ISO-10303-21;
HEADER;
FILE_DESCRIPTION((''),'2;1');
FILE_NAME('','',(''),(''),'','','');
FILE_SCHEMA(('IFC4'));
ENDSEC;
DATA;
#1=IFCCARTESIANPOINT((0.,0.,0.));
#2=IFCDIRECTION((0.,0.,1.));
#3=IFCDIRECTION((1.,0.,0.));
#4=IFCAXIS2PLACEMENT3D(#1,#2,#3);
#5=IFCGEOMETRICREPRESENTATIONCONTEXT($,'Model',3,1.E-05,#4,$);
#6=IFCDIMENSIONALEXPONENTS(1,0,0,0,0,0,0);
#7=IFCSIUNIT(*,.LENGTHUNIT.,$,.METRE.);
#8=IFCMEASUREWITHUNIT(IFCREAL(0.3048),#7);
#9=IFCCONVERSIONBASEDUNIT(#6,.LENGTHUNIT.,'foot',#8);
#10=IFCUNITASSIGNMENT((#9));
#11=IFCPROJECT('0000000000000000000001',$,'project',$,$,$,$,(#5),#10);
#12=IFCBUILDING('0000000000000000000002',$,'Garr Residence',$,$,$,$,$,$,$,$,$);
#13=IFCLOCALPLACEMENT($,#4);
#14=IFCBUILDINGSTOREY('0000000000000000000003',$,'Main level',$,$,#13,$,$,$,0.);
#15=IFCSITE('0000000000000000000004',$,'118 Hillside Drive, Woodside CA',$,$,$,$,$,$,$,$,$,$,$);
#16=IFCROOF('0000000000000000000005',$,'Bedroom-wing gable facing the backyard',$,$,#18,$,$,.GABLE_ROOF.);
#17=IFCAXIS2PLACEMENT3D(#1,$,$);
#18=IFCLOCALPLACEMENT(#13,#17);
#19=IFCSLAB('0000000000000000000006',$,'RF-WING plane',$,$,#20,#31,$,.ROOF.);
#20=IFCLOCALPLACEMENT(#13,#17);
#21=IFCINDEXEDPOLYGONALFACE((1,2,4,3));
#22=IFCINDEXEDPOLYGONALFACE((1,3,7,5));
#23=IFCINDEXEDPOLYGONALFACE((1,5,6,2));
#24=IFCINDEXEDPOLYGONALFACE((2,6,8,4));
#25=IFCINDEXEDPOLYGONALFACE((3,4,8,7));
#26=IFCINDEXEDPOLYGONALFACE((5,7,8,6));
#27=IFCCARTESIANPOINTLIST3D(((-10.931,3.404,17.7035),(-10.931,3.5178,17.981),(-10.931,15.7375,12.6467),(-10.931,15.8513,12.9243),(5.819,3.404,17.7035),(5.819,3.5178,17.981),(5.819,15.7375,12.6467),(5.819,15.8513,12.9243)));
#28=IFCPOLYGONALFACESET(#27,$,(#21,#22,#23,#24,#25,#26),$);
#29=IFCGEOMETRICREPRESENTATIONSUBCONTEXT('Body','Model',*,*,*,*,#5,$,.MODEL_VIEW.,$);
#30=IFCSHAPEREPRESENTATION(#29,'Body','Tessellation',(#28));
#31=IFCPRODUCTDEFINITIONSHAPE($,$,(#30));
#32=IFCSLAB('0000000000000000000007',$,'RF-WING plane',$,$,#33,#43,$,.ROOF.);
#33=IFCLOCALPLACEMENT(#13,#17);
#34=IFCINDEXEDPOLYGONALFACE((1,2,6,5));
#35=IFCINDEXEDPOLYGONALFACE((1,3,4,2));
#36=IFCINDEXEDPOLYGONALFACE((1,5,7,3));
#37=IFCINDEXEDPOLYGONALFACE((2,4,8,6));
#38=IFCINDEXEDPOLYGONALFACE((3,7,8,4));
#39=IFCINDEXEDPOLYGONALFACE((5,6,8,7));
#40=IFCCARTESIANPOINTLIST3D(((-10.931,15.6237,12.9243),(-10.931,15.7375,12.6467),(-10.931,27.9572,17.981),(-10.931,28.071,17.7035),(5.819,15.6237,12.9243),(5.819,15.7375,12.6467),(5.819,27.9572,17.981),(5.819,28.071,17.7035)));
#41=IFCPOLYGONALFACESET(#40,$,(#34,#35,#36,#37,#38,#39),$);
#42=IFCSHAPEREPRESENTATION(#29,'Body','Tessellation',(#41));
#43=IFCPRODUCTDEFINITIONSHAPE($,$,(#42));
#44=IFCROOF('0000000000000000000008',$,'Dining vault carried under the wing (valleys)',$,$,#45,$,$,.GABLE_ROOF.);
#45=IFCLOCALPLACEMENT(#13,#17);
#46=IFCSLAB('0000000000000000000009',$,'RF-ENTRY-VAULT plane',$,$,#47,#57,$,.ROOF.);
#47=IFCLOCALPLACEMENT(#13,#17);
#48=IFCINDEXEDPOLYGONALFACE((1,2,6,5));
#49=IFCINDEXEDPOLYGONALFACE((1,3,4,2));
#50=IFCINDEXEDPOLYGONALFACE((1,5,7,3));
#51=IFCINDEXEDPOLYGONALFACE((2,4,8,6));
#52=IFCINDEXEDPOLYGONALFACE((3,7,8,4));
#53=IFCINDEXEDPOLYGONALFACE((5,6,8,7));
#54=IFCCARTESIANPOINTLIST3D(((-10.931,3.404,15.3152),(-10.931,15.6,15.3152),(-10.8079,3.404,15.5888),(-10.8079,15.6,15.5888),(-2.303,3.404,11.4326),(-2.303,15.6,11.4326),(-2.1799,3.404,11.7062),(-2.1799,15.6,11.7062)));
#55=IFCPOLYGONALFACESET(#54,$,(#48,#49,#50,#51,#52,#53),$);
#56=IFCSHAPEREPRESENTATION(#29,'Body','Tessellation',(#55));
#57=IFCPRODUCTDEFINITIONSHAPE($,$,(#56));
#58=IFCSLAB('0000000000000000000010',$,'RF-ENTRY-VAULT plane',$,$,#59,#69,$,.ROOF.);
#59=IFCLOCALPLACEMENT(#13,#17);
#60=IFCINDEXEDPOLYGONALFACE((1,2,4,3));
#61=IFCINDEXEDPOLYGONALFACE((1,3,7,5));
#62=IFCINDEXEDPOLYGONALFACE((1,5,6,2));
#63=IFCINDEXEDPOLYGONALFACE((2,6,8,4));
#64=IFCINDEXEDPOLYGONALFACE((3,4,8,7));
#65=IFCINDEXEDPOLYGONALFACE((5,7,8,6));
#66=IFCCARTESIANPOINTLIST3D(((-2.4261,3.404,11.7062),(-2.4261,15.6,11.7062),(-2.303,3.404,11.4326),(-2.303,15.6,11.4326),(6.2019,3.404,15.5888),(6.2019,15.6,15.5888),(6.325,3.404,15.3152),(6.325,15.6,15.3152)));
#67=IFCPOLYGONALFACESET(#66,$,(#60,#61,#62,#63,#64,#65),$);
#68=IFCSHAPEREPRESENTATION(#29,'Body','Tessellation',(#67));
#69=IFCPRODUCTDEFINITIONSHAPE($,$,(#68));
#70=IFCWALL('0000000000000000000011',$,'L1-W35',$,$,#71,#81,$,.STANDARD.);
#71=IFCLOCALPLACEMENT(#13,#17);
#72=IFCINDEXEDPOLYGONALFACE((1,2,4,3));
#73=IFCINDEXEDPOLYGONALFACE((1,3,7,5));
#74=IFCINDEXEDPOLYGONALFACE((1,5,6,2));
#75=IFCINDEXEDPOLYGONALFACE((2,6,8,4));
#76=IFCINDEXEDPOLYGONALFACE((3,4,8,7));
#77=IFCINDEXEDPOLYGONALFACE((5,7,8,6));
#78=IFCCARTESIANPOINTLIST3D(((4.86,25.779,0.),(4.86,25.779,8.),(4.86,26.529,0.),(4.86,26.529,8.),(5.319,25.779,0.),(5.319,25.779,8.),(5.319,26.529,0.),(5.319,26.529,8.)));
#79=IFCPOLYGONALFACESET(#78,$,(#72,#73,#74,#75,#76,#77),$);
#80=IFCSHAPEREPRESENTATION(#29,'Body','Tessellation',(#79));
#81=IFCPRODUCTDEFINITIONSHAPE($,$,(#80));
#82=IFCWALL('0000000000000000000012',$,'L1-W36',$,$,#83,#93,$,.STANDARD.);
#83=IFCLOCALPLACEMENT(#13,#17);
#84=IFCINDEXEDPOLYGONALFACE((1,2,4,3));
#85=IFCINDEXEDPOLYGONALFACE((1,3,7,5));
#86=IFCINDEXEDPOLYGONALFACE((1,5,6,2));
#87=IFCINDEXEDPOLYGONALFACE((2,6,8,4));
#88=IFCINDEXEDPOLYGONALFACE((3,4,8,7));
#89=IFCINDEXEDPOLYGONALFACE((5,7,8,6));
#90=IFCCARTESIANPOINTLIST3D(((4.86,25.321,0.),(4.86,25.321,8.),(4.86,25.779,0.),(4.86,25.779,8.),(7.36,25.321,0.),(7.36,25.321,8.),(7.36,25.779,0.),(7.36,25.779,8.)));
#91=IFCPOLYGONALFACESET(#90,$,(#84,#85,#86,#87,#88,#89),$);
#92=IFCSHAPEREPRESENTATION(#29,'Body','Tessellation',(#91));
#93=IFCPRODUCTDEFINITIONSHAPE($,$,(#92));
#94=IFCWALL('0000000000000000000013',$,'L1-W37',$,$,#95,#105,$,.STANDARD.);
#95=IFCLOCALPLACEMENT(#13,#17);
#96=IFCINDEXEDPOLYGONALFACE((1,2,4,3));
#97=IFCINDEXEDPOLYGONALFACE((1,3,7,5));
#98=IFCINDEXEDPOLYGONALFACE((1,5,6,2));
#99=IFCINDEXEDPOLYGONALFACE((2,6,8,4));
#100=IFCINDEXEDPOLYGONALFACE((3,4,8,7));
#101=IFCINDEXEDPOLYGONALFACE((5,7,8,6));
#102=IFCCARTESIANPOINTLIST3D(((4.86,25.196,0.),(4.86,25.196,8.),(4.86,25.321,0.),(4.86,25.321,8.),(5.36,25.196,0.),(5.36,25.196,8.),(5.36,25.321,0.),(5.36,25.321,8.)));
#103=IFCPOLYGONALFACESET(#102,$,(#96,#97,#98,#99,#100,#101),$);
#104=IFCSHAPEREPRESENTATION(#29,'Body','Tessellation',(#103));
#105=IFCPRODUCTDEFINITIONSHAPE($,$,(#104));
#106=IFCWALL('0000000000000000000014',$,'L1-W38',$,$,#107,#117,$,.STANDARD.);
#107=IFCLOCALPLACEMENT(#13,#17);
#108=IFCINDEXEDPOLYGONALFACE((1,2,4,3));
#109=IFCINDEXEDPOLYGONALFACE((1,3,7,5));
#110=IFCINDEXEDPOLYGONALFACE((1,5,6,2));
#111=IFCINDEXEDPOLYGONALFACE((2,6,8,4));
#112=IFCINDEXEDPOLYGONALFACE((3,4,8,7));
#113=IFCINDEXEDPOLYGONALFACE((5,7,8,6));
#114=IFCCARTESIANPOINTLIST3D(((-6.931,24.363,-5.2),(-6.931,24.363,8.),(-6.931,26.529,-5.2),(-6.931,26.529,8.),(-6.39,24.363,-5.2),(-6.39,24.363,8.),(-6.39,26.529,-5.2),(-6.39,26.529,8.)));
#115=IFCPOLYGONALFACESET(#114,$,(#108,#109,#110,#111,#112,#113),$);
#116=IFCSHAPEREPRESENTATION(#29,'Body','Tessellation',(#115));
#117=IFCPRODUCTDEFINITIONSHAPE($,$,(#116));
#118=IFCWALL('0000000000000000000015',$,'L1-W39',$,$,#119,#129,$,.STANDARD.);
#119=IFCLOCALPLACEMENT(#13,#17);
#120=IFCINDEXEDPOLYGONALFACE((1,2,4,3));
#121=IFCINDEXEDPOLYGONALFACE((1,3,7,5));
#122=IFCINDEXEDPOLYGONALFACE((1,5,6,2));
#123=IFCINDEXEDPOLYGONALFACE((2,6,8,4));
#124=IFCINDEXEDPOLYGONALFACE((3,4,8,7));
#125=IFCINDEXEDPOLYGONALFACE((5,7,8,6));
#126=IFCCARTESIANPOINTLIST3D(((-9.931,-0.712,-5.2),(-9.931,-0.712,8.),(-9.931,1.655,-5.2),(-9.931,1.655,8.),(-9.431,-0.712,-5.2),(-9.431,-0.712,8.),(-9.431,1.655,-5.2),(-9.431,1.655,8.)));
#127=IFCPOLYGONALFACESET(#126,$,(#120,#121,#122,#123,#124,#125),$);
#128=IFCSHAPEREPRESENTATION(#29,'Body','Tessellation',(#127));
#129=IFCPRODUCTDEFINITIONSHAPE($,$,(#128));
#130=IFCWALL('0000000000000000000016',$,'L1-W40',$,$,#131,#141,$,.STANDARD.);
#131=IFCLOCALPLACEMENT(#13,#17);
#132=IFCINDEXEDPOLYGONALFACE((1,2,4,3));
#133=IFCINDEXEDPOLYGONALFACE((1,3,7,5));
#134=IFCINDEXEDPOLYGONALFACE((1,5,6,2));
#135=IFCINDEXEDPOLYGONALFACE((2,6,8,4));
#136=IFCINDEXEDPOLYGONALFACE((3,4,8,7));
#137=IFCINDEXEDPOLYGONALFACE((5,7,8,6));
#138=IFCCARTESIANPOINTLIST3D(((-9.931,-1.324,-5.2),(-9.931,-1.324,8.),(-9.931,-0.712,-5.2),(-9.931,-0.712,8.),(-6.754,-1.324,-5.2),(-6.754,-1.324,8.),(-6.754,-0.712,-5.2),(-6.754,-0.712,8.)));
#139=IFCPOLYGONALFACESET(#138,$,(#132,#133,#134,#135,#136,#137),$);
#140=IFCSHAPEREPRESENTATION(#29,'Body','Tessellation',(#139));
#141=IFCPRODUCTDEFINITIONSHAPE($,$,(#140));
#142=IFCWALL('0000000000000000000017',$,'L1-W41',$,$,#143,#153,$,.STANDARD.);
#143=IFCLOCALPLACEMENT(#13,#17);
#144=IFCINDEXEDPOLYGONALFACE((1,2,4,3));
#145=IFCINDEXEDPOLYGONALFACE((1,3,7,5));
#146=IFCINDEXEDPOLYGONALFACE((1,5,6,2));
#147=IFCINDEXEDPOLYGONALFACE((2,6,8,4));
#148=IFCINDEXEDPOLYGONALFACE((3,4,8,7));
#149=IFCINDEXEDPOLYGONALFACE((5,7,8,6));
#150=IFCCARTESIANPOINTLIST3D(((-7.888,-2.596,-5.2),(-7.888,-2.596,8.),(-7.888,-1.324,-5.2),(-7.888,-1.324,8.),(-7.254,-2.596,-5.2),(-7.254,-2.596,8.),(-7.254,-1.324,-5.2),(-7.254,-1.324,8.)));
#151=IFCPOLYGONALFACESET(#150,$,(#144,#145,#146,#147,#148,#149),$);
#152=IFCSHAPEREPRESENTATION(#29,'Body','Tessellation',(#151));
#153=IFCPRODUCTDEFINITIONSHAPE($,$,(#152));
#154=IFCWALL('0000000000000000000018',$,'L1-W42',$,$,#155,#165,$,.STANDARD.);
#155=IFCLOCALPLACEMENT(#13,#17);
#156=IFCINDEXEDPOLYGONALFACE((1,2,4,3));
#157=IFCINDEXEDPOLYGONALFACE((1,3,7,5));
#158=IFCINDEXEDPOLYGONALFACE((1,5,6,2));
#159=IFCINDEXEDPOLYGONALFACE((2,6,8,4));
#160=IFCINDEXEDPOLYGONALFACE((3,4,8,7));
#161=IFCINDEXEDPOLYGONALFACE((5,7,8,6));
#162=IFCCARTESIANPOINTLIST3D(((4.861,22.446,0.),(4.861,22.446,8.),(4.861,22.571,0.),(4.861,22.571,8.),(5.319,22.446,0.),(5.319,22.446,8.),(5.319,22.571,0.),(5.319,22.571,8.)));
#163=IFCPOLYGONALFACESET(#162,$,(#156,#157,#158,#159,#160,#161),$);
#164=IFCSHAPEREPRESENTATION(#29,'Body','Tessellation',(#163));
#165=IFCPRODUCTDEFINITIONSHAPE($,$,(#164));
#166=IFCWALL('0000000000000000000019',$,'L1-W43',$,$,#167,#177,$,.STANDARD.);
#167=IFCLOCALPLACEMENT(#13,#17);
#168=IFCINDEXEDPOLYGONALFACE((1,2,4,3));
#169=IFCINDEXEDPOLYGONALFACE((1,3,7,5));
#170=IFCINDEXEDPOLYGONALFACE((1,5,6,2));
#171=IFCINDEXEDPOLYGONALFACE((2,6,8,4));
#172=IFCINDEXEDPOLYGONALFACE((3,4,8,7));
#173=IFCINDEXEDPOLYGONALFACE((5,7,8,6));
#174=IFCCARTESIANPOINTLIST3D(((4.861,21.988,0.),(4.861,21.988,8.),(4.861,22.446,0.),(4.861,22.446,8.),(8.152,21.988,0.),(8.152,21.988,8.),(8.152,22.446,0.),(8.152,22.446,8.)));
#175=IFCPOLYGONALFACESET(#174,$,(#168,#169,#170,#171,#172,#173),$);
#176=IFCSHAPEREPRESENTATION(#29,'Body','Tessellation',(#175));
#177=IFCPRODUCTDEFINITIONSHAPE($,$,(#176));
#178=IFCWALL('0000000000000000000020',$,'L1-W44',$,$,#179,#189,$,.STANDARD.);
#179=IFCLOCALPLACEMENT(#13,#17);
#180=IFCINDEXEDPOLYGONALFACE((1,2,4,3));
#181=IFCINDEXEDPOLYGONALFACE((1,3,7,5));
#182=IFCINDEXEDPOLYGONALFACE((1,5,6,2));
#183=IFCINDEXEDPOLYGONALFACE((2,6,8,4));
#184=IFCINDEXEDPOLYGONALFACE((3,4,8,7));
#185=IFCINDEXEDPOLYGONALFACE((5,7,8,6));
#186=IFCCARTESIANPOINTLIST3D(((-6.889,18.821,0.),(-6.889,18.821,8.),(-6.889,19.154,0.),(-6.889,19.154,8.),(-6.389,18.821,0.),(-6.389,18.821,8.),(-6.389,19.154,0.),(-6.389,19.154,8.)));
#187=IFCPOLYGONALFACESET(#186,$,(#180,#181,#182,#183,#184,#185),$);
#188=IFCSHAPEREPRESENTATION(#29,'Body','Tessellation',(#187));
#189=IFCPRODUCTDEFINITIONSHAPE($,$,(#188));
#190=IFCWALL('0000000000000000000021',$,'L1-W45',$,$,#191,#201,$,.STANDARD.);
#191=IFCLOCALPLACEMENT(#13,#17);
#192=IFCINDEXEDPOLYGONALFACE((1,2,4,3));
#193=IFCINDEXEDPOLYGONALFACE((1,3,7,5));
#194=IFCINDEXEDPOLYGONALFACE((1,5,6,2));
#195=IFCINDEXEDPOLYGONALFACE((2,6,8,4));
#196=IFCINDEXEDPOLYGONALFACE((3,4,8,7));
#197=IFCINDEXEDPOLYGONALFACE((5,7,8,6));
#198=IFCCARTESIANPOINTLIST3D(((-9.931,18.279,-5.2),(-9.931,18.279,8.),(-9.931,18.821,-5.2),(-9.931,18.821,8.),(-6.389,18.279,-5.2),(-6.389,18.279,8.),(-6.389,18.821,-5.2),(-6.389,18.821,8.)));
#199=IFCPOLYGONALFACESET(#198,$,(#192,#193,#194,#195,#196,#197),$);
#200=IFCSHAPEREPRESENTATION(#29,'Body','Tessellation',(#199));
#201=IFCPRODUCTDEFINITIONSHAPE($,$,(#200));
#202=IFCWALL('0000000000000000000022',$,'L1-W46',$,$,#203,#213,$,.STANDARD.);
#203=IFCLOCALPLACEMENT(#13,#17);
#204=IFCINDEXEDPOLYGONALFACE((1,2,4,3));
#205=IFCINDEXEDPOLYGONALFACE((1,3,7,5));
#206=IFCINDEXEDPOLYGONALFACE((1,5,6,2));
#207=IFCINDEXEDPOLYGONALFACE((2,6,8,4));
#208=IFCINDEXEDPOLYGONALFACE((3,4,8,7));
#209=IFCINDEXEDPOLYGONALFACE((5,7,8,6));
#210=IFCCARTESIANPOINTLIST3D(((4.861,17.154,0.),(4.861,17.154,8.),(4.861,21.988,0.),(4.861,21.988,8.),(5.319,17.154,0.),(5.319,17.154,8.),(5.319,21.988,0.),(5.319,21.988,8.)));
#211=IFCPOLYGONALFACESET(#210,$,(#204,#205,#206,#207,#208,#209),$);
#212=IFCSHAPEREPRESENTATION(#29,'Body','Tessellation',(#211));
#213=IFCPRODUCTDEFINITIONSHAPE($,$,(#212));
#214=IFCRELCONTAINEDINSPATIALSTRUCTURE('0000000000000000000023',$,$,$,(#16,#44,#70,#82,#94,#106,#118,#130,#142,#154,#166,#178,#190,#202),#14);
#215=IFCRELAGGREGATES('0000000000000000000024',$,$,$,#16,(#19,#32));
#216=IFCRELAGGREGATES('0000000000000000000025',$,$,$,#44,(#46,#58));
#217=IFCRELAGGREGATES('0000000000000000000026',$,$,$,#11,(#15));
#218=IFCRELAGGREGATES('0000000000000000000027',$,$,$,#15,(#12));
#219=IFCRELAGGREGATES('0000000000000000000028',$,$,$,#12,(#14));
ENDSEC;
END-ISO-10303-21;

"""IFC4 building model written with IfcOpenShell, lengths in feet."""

from ifc_helpers import new_model, entity, si_unit, converted_unit, frame, origin, origin_with_axes, place, context, subcontext, project, spatial, polyline, outline, extrude, element, aggregate, save


model = new_model("IFC4")

# Units and contexts
model_context = context("Model", 3, precision=1e-05, world=origin_with_axes())
body_context = subcontext(model_context, "Body", "Model", "MODEL_VIEW")
ifc_project = project(units=[converted_unit("LENGTHUNIT", "foot", entity("IfcReal", 0.3048), si_unit("LENGTHUNIT", "METRE"), dimensions=[1, 0, 0, 0, 0, 0, 0])], contexts=[model_context])

# Site, building, storey
site = spatial("IfcSite", under=ifc_project, Name="118 Hillside Drive, Woodside CA")
building = spatial("IfcBuilding", under=site, Name="Garr Residence")
storey_placement = place(None, origin_with_axes())
storey = spatial("IfcBuildingStorey", under=building, at=storey_placement, Name="Main level", Elevation=0.0)

# Roofs, slabs
roof_1 = element("IfcRoof", 1, inside=storey, Name="Bedroom-wing gable facing the backyard", PredefinedType="GABLE_ROOF")
slab_1_placement = place(None, frame((-10.931, 15.7375, 12.6467), z_axis=(0.0, 0.379353, 0.925252), x_axis=(1.0, 0.0, 0.0)))
slab_1 = element("IfcSlab", 2, at=slab_1_placement, Name="RF-WING plane", PredefinedType="ROOF", context=body_context, shape_type="SweptSolid", body=[
    extrude(outline(polyline([(0.0, 0.0), (16.75, 0.0), (16.75, -13.3299), (0.0, -13.3299), (0.0, 0.0)])), origin(), (0.0, 0.0, 1.0), 0.3),
])
slab_2_placement = place(None, frame((-10.931, 15.7375, 12.6467), z_axis=(0.0, -0.379353, 0.925252), x_axis=(1.0, 0.0, 0.0)))
slab_2 = element("IfcSlab", 3, at=slab_2_placement, Name="RF-WING plane", PredefinedType="ROOF", context=body_context, shape_type="SweptSolid", body=[
    extrude(outline(polyline([(0.0, 0.0), (16.75, 0.0), (16.75, 13.3299), (0.0, 13.3299), (0.0, 0.0)])), origin(), (0.0, 0.0, 1.0), 0.3),
])
aggregate(roof_1, [slab_1, slab_2])
roof_2 = element("IfcRoof", 4, inside=storey, Name="Dining vault carried under the wing (valleys)", PredefinedType="GABLE_ROOF")
slab_3_placement = place(None, frame((-2.303, 3.404, 11.4326), z_axis=(0.410365, 0.0, 0.911922), x_axis=(0.0, 1.0, 0.0)))
slab_3 = element("IfcSlab", 5, at=slab_3_placement, Name="RF-ENTRY-VAULT plane", PredefinedType="ROOF", context=body_context, shape_type="SweptSolid", body=[
    extrude(outline(polyline([(0.0, 0.0), (12.196, 0.0), (12.196, 9.4613), (0.0, 9.4613), (0.0, 0.0)])), origin(), (0.0, 0.0, 1.0), 0.3),
])
slab_4_placement = place(None, frame((-2.303, 3.404, 11.4326), z_axis=(-0.410365, 0.0, 0.911922), x_axis=(0.0, 1.0, 0.0)))
slab_4 = element("IfcSlab", 6, at=slab_4_placement, Name="RF-ENTRY-VAULT plane", PredefinedType="ROOF", context=body_context, shape_type="SweptSolid", body=[
    extrude(outline(polyline([(0.0, 0.0), (12.196, 0.0), (12.196, -9.4613), (0.0, -9.4613), (0.0, 0.0)])), origin(), (0.0, 0.0, 1.0), 0.3),
])
aggregate(roof_2, [slab_3, slab_4])

# Walls
wall_1_placement = place(storey_placement, origin_with_axes())
element("IfcWall", 7, at=wall_1_placement, inside=storey, Name="L1-W35", PredefinedType="STANDARD", context=body_context, shape_type="SweptSolid", body=[
    extrude(outline(polyline([(5.319, 25.779), (5.319, 26.529), (4.86, 26.529), (4.86, 25.779), (5.319, 25.779)])), origin(), (0.0, 0.0, 1.0), 8.0),
])
wall_2_placement = place(storey_placement, origin_with_axes())
element("IfcWall", 8, at=wall_2_placement, inside=storey, Name="L1-W36", PredefinedType="STANDARD", context=body_context, shape_type="SweptSolid", body=[
    extrude(outline(polyline([(7.36, 25.321), (7.36, 25.779), (4.86, 25.779), (4.86, 25.321), (7.36, 25.321)])), origin(), (0.0, 0.0, 1.0), 8.0),
])
wall_3_placement = place(storey_placement, origin_with_axes())
element("IfcWall", 9, at=wall_3_placement, inside=storey, Name="L1-W37", PredefinedType="STANDARD", context=body_context, shape_type="SweptSolid", body=[
    extrude(outline(polyline([(5.36, 25.196), (5.36, 25.321), (4.86, 25.321), (4.86, 25.196), (5.36, 25.196)])), origin(), (0.0, 0.0, 1.0), 8.0),
])
wall_4_placement = place(storey_placement, frame((0.0, 0.0, -5.2), z_axis=(0.0, 0.0, 1.0), x_axis=(1.0, 0.0, 0.0)))
element("IfcWall", 10, at=wall_4_placement, inside=storey, Name="L1-W38", PredefinedType="STANDARD", context=body_context, shape_type="SweptSolid", body=[
    extrude(outline(polyline([(-6.39, 24.363), (-6.39, 26.529), (-6.931, 26.529), (-6.931, 24.363), (-6.39, 24.363)])), origin(), (0.0, 0.0, 1.0), 13.2),
])
wall_5_placement = place(storey_placement, frame((0.0, 0.0, -5.2), z_axis=(0.0, 0.0, 1.0), x_axis=(1.0, 0.0, 0.0)))
element("IfcWall", 11, at=wall_5_placement, inside=storey, Name="L1-W39", PredefinedType="STANDARD", context=body_context, shape_type="SweptSolid", body=[
    extrude(outline(polyline([(-9.431, -0.712), (-9.431, 1.655), (-9.931, 1.655), (-9.931, -0.712), (-9.431, -0.712)])), origin(), (0.0, 0.0, 1.0), 13.2),
])
wall_6_placement = place(storey_placement, frame((0.0, 0.0, -5.2), z_axis=(0.0, 0.0, 1.0), x_axis=(1.0, 0.0, 0.0)))
element("IfcWall", 12, at=wall_6_placement, inside=storey, Name="L1-W40", PredefinedType="STANDARD", context=body_context, shape_type="SweptSolid", body=[
    extrude(outline(polyline([(-6.754, -1.324), (-6.754, -0.712), (-9.931, -0.712), (-9.931, -1.324), (-6.754, -1.324)])), origin(), (0.0, 0.0, 1.0), 13.2),
])
wall_7_placement = place(storey_placement, frame((0.0, 0.0, -5.2), z_axis=(0.0, 0.0, 1.0), x_axis=(1.0, 0.0, 0.0)))
element("IfcWall", 13, at=wall_7_placement, inside=storey, Name="L1-W41", PredefinedType="STANDARD", context=body_context, shape_type="SweptSolid", body=[
    extrude(outline(polyline([(-7.254, -2.596), (-7.254, -1.324), (-7.888, -1.324), (-7.888, -2.596), (-7.254, -2.596)])), origin(), (0.0, 0.0, 1.0), 13.2),
])
wall_8_placement = place(storey_placement, origin_with_axes())
element("IfcWall", 14, at=wall_8_placement, inside=storey, Name="L1-W42", PredefinedType="STANDARD", context=body_context, shape_type="SweptSolid", body=[
    extrude(outline(polyline([(5.319, 22.446), (5.319, 22.571), (4.861, 22.571), (4.861, 22.446), (5.319, 22.446)])), origin(), (0.0, 0.0, 1.0), 8.0),
])
wall_9_placement = place(storey_placement, origin_with_axes())
element("IfcWall", 15, at=wall_9_placement, inside=storey, Name="L1-W43", PredefinedType="STANDARD", context=body_context, shape_type="SweptSolid", body=[
    extrude(outline(polyline([(8.152, 21.988), (8.152, 22.446), (4.861, 22.446), (4.861, 21.988), (8.152, 21.988)])), origin(), (0.0, 0.0, 1.0), 8.0),
])
wall_10_placement = place(storey_placement, origin_with_axes())
element("IfcWall", 16, at=wall_10_placement, inside=storey, Name="L1-W44", PredefinedType="STANDARD", context=body_context, shape_type="SweptSolid", body=[
    extrude(outline(polyline([(-6.389, 18.821), (-6.389, 19.154), (-6.889, 19.154), (-6.889, 18.821), (-6.389, 18.821)])), origin(), (0.0, 0.0, 1.0), 8.0),
])
wall_11_placement = place(storey_placement, frame((0.0, 0.0, -5.2), z_axis=(0.0, 0.0, 1.0), x_axis=(1.0, 0.0, 0.0)))
element("IfcWall", 17, at=wall_11_placement, inside=storey, Name="L1-W45", PredefinedType="STANDARD", context=body_context, shape_type="SweptSolid", body=[
    extrude(outline(polyline([(-6.389, 18.279), (-6.389, 18.821), (-9.931, 18.821), (-9.931, 18.279), (-6.389, 18.279)])), origin(), (0.0, 0.0, 1.0), 13.2),
])
wall_12_placement = place(storey_placement, origin_with_axes())
element("IfcWall", 18, at=wall_12_placement, inside=storey, Name="L1-W46", PredefinedType="STANDARD", context=body_context, shape_type="SweptSolid", body=[
    extrude(outline(polyline([(5.319, 17.154), (5.319, 21.988), (4.861, 21.988), (4.861, 17.154), (5.319, 17.154)])), origin(), (0.0, 0.0, 1.0), 8.0),
])

save(model, "model.ifc")
